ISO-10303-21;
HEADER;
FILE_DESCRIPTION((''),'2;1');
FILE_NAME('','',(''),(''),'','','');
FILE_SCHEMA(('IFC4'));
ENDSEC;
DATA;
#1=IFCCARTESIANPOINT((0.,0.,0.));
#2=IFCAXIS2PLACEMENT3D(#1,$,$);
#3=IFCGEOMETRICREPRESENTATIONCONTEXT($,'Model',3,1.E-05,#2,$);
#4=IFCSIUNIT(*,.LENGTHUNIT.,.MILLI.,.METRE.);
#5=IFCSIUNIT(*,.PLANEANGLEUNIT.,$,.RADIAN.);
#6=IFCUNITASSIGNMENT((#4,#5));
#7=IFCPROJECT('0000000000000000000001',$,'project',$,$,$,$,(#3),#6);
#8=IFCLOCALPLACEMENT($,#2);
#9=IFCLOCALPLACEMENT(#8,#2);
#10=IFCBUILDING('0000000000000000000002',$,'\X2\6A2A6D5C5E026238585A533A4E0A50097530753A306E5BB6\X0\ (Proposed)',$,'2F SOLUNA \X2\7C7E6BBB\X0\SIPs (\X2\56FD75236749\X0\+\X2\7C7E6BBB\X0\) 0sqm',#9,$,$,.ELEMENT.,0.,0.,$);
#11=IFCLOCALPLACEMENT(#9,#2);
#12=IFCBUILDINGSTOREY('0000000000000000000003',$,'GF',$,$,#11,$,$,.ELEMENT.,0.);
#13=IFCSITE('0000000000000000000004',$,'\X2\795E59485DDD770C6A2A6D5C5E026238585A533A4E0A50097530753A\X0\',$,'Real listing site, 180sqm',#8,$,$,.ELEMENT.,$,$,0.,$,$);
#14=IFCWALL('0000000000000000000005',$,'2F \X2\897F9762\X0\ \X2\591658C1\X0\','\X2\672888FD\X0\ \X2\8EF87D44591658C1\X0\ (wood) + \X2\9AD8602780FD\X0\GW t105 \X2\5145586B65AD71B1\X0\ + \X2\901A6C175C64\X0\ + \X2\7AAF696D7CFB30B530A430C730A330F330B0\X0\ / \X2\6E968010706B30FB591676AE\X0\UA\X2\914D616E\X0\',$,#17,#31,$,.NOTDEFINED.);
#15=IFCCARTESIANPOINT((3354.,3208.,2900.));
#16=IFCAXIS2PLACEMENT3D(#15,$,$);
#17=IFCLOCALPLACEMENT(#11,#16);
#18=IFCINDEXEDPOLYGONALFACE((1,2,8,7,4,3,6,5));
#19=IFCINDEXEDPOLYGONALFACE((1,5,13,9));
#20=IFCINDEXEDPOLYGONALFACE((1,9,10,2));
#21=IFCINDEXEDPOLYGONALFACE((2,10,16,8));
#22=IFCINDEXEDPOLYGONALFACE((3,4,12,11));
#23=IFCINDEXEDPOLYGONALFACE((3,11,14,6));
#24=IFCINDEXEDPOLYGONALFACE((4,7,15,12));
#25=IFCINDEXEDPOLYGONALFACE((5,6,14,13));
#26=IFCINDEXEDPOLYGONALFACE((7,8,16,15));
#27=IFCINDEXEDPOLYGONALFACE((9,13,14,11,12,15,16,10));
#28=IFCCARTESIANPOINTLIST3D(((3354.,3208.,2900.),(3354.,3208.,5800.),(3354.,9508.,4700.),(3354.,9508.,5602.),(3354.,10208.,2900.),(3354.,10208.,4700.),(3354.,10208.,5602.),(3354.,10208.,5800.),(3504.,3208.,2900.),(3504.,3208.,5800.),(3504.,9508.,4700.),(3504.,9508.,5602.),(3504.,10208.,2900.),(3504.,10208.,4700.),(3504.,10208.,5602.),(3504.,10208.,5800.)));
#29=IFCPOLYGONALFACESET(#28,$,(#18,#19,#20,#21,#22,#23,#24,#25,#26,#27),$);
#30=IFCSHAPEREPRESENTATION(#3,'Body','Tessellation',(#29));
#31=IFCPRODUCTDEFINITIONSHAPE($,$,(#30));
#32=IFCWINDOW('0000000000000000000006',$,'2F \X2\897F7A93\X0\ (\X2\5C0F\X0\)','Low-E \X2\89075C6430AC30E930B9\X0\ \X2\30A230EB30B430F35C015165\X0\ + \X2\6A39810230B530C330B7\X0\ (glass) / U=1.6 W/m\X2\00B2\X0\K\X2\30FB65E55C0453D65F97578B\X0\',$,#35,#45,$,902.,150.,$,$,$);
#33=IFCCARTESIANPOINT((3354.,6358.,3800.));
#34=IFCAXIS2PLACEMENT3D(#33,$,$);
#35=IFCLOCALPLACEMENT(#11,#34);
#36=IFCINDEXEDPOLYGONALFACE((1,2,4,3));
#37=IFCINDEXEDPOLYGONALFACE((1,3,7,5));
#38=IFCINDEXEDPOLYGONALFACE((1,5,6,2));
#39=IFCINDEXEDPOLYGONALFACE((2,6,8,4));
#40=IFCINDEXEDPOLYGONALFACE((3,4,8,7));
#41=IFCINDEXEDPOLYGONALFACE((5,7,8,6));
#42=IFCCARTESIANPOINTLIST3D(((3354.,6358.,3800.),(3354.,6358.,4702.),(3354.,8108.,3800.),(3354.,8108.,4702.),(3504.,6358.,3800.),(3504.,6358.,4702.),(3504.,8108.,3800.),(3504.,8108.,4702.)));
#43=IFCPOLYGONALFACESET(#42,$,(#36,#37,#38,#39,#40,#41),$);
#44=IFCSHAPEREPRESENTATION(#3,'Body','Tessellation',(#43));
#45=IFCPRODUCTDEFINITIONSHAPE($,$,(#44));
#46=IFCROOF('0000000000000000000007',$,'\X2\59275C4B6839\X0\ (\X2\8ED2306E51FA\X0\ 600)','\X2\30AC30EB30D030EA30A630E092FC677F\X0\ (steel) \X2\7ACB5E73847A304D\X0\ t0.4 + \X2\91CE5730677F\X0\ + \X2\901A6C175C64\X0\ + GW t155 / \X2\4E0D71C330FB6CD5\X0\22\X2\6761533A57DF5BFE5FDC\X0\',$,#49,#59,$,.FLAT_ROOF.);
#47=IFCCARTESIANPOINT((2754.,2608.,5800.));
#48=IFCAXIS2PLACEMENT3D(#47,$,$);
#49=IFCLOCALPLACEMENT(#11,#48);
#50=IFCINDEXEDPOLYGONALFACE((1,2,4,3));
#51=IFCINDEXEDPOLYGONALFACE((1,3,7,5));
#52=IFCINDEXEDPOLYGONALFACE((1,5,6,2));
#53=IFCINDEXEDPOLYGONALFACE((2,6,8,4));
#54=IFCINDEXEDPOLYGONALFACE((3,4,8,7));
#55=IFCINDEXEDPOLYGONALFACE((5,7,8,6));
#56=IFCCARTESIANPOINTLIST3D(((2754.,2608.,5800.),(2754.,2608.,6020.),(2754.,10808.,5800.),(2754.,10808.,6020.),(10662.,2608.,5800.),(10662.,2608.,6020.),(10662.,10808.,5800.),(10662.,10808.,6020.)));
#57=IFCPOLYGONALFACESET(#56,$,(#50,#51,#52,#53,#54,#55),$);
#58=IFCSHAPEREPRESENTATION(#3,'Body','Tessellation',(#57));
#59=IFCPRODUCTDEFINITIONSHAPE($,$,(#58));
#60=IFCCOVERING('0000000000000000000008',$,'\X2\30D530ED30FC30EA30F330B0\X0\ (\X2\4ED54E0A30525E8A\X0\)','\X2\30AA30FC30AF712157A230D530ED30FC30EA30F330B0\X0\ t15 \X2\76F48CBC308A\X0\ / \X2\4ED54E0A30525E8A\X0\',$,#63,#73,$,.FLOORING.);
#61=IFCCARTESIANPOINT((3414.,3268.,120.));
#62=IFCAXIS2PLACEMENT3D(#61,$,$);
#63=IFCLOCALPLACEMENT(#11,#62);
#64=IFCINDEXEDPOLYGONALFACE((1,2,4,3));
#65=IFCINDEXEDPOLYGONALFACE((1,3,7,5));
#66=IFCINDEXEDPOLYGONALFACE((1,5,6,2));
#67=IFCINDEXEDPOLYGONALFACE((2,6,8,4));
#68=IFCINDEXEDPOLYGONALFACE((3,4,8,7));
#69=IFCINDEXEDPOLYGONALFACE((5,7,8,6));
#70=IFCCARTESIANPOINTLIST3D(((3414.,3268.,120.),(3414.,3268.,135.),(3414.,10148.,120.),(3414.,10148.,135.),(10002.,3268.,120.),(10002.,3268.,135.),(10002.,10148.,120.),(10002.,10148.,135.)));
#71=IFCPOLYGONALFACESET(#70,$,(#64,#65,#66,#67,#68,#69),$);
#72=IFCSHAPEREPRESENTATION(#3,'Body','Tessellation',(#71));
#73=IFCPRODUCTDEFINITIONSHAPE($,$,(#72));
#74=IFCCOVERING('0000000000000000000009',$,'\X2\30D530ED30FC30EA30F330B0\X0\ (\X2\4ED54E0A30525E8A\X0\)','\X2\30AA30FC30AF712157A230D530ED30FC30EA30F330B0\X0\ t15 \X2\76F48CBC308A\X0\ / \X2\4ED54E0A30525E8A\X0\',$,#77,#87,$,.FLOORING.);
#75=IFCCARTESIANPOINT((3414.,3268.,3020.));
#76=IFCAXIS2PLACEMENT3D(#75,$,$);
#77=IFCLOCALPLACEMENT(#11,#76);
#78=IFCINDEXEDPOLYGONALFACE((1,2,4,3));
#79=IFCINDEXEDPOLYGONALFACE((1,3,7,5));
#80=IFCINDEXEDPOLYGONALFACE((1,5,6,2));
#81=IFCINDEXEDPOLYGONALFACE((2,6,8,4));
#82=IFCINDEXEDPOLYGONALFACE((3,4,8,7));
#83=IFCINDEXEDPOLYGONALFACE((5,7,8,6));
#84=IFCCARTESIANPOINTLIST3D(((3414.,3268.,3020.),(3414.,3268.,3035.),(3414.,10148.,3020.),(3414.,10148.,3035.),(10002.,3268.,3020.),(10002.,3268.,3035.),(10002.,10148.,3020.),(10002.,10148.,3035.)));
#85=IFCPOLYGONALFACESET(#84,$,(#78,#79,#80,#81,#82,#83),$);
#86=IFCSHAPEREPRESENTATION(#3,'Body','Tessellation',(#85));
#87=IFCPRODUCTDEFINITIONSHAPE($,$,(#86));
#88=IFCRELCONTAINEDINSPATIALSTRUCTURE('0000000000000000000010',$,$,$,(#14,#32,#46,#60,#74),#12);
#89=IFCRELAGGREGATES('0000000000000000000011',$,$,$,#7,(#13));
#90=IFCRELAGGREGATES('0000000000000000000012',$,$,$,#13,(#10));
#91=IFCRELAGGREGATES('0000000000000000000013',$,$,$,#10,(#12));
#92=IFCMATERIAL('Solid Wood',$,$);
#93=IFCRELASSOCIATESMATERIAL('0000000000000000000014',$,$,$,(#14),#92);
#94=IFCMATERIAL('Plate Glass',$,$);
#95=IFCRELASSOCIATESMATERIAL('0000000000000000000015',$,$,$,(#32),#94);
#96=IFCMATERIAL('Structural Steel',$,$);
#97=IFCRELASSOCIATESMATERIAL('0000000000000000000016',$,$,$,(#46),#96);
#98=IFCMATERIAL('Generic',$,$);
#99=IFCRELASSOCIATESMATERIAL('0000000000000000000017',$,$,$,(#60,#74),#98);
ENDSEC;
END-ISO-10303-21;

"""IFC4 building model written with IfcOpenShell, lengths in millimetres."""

from ifc_helpers import new_model, si_unit, frame, frame_2d, origin, place, context, project, spatial, rectangle, extrude, material, element, fill, save


model = new_model("IFC4")

# Units and contexts
model_context = context("Model", 3, precision=1e-05, world=origin())
ifc_project = project(units=[si_unit("LENGTHUNIT", "METRE", prefix="MILLI"), si_unit("PLANEANGLEUNIT", "RADIAN")], contexts=[model_context])

# Site, building, storey
site_placement = place(None, origin())
site = spatial("IfcSite", under=ifc_project, at=site_placement, Name="神奈川県横浜市戸塚区上倉田町", ObjectType="Real listing site, 180sqm", CompositionType="ELEMENT", RefElevation=0.0)
building_placement = place(site_placement, origin())
building = spatial("IfcBuilding", under=site, at=building_placement, Name="横浜市戸塚区上倉田町の家 (Proposed)", ObjectType="2F SOLUNA 籾殻SIPs (国産杉+籾殻) 0sqm", CompositionType="ELEMENT", ElevationOfRefHeight=0.0, ElevationOfTerrain=0.0)
storey_placement = place(building_placement, origin())
storey = spatial("IfcBuildingStorey", under=building, at=storey_placement, Name="GF", CompositionType="ELEMENT", Elevation=0.0)

# Shared definitions
ifc_material_1 = material(Name="Solid Wood")

# Shared definitions
ifc_material_2 = material(Name="Plate Glass")

# Wall, opening, window
wall_1_placement = place(storey_placement, frame((3354.0, 3208.0, 2900.0)))
wall_1 = element("IfcWall", 1, at=wall_1_placement, inside=storey, material=ifc_material_1, Name="2F 西面 外壁", Description="木製 軸組外壁 (wood) + 高性能GW t105 充填断熱 + 通気層 + 窯業系サイディング / 準耐火・外皮UA配慮", PredefinedType="NOTDEFINED", context=model_context, shape_type="SweptSolid", body=[
    extrude(rectangle(XDim=150.0, YDim=7000.0, at=frame_2d((75.0, 3500.0))), frame((3354.0, 3208.0, 2900.0)), (0.0, 0.0, 1.0), 2900.0),
])
opening_1_placement = place(storey_placement, frame((3354.0, 6358.0, 3800.0)))
opening_1 = element("IfcOpeningElement", 2, at=opening_1_placement, cuts=wall_1, PredefinedType="NOTDEFINED", context=model_context, shape_type="SweptSolid", body=[
    extrude(rectangle(XDim=150.0, YDim=1750.0, at=frame_2d((75.0, 875.0))), frame((3354.0, 6358.0, 3800.0)), (0.0, 0.0, 1.0), 902.0),
])
window_1_placement = place(storey_placement, frame((3354.0, 6358.0, 3800.0)))
window_1 = element("IfcWindow", 3, at=window_1_placement, inside=storey, material=ifc_material_2, Name="2F 西窓 (小)", Description="Low-E 複層ガラス アルゴン封入 + 樹脂サッシ (glass) / U=1.6 W/m²K・日射取得型", OverallHeight=902.0, OverallWidth=150.0, context=model_context, shape_type="SweptSolid", body=[
    extrude(rectangle(XDim=150.0, YDim=1750.0, at=frame_2d((75.0, 875.0))), frame((3354.0, 6358.0, 3800.0)), (0.0, 0.0, 1.0), 902.0),
])
fill(opening_1, window_1)

# Roof
ifc_material_3 = material(Name="Structural Steel")
roof_placement = place(storey_placement, frame((2754.0, 2608.0, 5800.0)))
element("IfcRoof", 4, at=roof_placement, inside=storey, material=ifc_material_3, Name="大屋根 (軒の出 600)", Description="ガルバリウム鋼板 (steel) 立平葺き t0.4 + 野地板 + 通気層 + GW t155 / 不燃・法22条区域対応", PredefinedType="FLAT_ROOF", context=model_context, shape_type="SweptSolid", body=[
    extrude(rectangle(XDim=7908.0, YDim=8200.0, at=frame_2d((3954.0, 4100.0))), frame((2754.0, 2608.0, 5800.0)), (0.0, 0.0, 1.0), 220.0),
])

# Coverings
ifc_material_4 = material(Name="Generic")
covering_1_placement = place(storey_placement, frame((3414.0, 3268.0, 120.0)))
element("IfcCovering", 5, at=covering_1_placement, inside=storey, material=ifc_material_4, Name="フローリング (仕上げ床)", Description="オーク無垢フローリング t15 直貼り / 仕上げ床", PredefinedType="FLOORING", context=model_context, shape_type="SweptSolid", body=[
    extrude(rectangle(XDim=6588.0, YDim=6880.0, at=frame_2d((3294.0, 3440.0))), frame((3414.0, 3268.0, 120.0)), (0.0, 0.0, 1.0), 15.0),
])
covering_2_placement = place(storey_placement, frame((3414.0, 3268.0, 3020.0)))
element("IfcCovering", 6, at=covering_2_placement, inside=storey, material=ifc_material_4, Name="フローリング (仕上げ床)", Description="オーク無垢フローリング t15 直貼り / 仕上げ床", PredefinedType="FLOORING", context=model_context, shape_type="SweptSolid", body=[
    extrude(rectangle(XDim=6588.0, YDim=6880.0, at=frame_2d((3294.0, 3440.0))), frame((3414.0, 3268.0, 3020.0)), (0.0, 0.0, 1.0), 15.0),
])

save(model, "model.ifc")
